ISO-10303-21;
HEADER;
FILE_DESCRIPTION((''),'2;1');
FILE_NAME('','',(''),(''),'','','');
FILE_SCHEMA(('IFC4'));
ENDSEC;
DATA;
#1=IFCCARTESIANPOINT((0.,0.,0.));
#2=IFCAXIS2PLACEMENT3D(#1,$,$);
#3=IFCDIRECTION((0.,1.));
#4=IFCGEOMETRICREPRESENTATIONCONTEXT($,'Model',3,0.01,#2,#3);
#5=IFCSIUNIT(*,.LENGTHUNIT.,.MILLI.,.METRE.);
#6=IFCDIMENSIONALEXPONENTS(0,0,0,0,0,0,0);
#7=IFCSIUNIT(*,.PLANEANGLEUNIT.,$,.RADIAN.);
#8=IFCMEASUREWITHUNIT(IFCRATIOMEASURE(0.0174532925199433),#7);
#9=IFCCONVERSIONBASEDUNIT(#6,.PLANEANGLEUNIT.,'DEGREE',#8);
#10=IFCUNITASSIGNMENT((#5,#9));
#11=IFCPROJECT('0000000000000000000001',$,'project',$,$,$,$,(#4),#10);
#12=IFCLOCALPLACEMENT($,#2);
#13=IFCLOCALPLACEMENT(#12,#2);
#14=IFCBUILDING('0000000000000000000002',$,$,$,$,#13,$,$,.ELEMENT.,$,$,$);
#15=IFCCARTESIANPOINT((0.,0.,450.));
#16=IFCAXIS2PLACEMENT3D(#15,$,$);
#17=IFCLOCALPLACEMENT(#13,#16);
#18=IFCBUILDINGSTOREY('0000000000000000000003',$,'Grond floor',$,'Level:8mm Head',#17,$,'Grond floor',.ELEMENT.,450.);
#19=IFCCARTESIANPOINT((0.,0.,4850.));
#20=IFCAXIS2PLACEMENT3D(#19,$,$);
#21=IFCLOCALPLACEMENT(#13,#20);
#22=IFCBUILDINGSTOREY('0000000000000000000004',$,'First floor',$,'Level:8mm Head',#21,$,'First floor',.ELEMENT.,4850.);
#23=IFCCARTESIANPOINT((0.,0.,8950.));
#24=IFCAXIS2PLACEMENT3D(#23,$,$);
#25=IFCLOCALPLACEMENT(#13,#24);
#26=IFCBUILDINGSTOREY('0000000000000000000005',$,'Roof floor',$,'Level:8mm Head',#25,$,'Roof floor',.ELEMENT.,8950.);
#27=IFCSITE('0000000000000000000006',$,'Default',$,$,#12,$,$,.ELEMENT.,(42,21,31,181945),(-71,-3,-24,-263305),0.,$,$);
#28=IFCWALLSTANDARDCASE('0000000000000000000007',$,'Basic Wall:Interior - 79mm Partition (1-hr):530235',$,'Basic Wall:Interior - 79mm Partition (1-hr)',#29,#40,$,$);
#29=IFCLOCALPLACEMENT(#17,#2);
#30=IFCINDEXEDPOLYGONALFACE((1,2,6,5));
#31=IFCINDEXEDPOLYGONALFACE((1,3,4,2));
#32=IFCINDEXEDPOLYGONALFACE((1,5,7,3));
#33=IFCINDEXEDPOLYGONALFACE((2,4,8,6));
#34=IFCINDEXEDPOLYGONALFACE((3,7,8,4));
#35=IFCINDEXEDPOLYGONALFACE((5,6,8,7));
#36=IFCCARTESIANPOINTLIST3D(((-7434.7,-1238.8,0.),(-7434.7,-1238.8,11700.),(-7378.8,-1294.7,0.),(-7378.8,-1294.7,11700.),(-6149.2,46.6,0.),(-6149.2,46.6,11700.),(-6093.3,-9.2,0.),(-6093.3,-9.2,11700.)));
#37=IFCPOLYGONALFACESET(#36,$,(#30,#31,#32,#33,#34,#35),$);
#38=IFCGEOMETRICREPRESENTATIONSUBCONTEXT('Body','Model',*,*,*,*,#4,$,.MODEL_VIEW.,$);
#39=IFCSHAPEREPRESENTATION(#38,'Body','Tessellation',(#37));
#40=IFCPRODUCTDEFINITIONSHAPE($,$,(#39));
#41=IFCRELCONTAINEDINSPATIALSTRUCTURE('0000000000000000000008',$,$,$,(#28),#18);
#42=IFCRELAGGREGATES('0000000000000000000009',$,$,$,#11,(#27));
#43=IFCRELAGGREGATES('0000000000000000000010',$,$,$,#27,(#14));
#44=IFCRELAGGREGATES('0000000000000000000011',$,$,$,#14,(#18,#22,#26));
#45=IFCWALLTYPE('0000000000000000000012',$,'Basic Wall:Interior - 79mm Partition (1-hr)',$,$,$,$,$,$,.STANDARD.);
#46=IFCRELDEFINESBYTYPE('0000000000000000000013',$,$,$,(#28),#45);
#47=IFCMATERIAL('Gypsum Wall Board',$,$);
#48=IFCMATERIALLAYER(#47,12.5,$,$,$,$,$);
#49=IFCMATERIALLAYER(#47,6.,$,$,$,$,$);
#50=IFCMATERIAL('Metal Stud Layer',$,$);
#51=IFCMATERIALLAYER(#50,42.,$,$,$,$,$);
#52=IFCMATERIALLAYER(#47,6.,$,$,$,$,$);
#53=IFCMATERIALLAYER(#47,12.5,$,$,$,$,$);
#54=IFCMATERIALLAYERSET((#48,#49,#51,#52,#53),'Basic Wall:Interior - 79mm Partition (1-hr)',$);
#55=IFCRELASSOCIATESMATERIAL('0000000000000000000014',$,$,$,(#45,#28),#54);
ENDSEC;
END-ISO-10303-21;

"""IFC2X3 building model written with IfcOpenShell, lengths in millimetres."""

from ifc_helpers import new_model, entity, si_unit, converted_unit, direction, frame, frame_2d, origin, place, context, subcontext, project, spatial, rectangle, extrude, material, layer, layer_set, layer_usage, type_object, element, save


model = new_model("IFC2X3")

# Units and contexts
model_context = context("Model", 3, precision=0.01, world=origin(), true_north=direction((0.0, 1.0)))
body_context = subcontext(model_context, "Body", "Model", "MODEL_VIEW")
ifc_project = project(units=[si_unit("LENGTHUNIT", "METRE", prefix="MILLI"), converted_unit("PLANEANGLEUNIT", "DEGREE", entity("IfcRatioMeasure", 0.0174532925199433), si_unit("PLANEANGLEUNIT", "RADIAN"), dimensions=[0, 0, 0, 0, 0, 0, 0])], contexts=[model_context])

# Site, building, storey
site_placement = place(None, origin())
site = spatial("IfcSite", under=ifc_project, at=site_placement, Name="Default", CompositionType="ELEMENT", RefLatitude=(42, 21, 31, 181945), RefLongitude=(-71, -3, -24, -263305), RefElevation=0.0)
building_placement = place(site_placement, origin())
building = spatial("IfcBuilding", under=site, at=building_placement, CompositionType="ELEMENT")
storey_1_placement = place(building_placement, frame((0.0, 0.0, 450.0)))
storey_1 = spatial("IfcBuildingStorey", under=building, at=storey_1_placement, Name="Grond floor", ObjectType="Level:8mm Head", LongName="Grond floor", CompositionType="ELEMENT", Elevation=450.0)

# Shared definitions
ifc_material_1 = material(Name="Gypsum Wall Board")

# Shared definitions
ifc_layer_1 = layer(ifc_material_1, 12.5)
ifc_layer_2 = layer(ifc_material_1, 6.0)
ifc_material_2 = material(Name="Metal Stud Layer")
ifc_layer_3 = layer(ifc_material_2, 42.0)
ifc_layer_4 = layer(ifc_material_1, 6.0)
ifc_layer_5 = layer(ifc_material_1, 12.5)
ifc_layer_set_1 = layer_set([ifc_layer_1, ifc_layer_2, ifc_layer_3, ifc_layer_4, ifc_layer_5], Name="Basic Wall:Interior - 79mm Partition (1-hr)")
wall_type_1 = type_object("IfcWallType", Name="Basic Wall:Interior - 79mm Partition (1-hr)", PredefinedType="STANDARD", material=ifc_layer_set_1)

# Shared definitions
storey_2_placement = place(building_placement, frame((0.0, 0.0, 4850.0)))
storey_2 = spatial("IfcBuildingStorey", under=building, at=storey_2_placement, Name="First floor", ObjectType="Level:8mm Head", LongName="First floor", CompositionType="ELEMENT", Elevation=4850.0)

# Shared definitions
storey_3_placement = place(building_placement, frame((0.0, 0.0, 8950.0)))
storey_3 = spatial("IfcBuildingStorey", under=building, at=storey_3_placement, Name="Roof floor", ObjectType="Level:8mm Head", LongName="Roof floor", CompositionType="ELEMENT", Elevation=8950.0)

# Wall
ifc_layer_usage_1 = layer_usage(ifc_layer_set_1, "AXIS2", "NEGATIVE", 39.5)
wall_1_placement = place(storey_1_placement, frame((-6121.3, 18.7, 0.0), z_axis=(0.0, 0.0, 1.0), x_axis=(-0.707107, -0.707107, 0.0)))
element("IfcWallStandardCase", 1, at=wall_1_placement, inside=storey_1, type_object=wall_type_1, material=ifc_layer_usage_1, Name="Basic Wall:Interior - 79mm Partition (1-hr):530235", ObjectType="Basic Wall:Interior - 79mm Partition (1-hr)", context=body_context, shape_type="SweptSolid", body=[
    extrude(rectangle(XDim=1818.0, YDim=79.0, at=frame_2d((909.0, 0.0), x_axis=(-1.0, 0.0))), origin(), (0.0, 0.0, 1.0), 11700.0),
])

save(model, "model.ifc")
